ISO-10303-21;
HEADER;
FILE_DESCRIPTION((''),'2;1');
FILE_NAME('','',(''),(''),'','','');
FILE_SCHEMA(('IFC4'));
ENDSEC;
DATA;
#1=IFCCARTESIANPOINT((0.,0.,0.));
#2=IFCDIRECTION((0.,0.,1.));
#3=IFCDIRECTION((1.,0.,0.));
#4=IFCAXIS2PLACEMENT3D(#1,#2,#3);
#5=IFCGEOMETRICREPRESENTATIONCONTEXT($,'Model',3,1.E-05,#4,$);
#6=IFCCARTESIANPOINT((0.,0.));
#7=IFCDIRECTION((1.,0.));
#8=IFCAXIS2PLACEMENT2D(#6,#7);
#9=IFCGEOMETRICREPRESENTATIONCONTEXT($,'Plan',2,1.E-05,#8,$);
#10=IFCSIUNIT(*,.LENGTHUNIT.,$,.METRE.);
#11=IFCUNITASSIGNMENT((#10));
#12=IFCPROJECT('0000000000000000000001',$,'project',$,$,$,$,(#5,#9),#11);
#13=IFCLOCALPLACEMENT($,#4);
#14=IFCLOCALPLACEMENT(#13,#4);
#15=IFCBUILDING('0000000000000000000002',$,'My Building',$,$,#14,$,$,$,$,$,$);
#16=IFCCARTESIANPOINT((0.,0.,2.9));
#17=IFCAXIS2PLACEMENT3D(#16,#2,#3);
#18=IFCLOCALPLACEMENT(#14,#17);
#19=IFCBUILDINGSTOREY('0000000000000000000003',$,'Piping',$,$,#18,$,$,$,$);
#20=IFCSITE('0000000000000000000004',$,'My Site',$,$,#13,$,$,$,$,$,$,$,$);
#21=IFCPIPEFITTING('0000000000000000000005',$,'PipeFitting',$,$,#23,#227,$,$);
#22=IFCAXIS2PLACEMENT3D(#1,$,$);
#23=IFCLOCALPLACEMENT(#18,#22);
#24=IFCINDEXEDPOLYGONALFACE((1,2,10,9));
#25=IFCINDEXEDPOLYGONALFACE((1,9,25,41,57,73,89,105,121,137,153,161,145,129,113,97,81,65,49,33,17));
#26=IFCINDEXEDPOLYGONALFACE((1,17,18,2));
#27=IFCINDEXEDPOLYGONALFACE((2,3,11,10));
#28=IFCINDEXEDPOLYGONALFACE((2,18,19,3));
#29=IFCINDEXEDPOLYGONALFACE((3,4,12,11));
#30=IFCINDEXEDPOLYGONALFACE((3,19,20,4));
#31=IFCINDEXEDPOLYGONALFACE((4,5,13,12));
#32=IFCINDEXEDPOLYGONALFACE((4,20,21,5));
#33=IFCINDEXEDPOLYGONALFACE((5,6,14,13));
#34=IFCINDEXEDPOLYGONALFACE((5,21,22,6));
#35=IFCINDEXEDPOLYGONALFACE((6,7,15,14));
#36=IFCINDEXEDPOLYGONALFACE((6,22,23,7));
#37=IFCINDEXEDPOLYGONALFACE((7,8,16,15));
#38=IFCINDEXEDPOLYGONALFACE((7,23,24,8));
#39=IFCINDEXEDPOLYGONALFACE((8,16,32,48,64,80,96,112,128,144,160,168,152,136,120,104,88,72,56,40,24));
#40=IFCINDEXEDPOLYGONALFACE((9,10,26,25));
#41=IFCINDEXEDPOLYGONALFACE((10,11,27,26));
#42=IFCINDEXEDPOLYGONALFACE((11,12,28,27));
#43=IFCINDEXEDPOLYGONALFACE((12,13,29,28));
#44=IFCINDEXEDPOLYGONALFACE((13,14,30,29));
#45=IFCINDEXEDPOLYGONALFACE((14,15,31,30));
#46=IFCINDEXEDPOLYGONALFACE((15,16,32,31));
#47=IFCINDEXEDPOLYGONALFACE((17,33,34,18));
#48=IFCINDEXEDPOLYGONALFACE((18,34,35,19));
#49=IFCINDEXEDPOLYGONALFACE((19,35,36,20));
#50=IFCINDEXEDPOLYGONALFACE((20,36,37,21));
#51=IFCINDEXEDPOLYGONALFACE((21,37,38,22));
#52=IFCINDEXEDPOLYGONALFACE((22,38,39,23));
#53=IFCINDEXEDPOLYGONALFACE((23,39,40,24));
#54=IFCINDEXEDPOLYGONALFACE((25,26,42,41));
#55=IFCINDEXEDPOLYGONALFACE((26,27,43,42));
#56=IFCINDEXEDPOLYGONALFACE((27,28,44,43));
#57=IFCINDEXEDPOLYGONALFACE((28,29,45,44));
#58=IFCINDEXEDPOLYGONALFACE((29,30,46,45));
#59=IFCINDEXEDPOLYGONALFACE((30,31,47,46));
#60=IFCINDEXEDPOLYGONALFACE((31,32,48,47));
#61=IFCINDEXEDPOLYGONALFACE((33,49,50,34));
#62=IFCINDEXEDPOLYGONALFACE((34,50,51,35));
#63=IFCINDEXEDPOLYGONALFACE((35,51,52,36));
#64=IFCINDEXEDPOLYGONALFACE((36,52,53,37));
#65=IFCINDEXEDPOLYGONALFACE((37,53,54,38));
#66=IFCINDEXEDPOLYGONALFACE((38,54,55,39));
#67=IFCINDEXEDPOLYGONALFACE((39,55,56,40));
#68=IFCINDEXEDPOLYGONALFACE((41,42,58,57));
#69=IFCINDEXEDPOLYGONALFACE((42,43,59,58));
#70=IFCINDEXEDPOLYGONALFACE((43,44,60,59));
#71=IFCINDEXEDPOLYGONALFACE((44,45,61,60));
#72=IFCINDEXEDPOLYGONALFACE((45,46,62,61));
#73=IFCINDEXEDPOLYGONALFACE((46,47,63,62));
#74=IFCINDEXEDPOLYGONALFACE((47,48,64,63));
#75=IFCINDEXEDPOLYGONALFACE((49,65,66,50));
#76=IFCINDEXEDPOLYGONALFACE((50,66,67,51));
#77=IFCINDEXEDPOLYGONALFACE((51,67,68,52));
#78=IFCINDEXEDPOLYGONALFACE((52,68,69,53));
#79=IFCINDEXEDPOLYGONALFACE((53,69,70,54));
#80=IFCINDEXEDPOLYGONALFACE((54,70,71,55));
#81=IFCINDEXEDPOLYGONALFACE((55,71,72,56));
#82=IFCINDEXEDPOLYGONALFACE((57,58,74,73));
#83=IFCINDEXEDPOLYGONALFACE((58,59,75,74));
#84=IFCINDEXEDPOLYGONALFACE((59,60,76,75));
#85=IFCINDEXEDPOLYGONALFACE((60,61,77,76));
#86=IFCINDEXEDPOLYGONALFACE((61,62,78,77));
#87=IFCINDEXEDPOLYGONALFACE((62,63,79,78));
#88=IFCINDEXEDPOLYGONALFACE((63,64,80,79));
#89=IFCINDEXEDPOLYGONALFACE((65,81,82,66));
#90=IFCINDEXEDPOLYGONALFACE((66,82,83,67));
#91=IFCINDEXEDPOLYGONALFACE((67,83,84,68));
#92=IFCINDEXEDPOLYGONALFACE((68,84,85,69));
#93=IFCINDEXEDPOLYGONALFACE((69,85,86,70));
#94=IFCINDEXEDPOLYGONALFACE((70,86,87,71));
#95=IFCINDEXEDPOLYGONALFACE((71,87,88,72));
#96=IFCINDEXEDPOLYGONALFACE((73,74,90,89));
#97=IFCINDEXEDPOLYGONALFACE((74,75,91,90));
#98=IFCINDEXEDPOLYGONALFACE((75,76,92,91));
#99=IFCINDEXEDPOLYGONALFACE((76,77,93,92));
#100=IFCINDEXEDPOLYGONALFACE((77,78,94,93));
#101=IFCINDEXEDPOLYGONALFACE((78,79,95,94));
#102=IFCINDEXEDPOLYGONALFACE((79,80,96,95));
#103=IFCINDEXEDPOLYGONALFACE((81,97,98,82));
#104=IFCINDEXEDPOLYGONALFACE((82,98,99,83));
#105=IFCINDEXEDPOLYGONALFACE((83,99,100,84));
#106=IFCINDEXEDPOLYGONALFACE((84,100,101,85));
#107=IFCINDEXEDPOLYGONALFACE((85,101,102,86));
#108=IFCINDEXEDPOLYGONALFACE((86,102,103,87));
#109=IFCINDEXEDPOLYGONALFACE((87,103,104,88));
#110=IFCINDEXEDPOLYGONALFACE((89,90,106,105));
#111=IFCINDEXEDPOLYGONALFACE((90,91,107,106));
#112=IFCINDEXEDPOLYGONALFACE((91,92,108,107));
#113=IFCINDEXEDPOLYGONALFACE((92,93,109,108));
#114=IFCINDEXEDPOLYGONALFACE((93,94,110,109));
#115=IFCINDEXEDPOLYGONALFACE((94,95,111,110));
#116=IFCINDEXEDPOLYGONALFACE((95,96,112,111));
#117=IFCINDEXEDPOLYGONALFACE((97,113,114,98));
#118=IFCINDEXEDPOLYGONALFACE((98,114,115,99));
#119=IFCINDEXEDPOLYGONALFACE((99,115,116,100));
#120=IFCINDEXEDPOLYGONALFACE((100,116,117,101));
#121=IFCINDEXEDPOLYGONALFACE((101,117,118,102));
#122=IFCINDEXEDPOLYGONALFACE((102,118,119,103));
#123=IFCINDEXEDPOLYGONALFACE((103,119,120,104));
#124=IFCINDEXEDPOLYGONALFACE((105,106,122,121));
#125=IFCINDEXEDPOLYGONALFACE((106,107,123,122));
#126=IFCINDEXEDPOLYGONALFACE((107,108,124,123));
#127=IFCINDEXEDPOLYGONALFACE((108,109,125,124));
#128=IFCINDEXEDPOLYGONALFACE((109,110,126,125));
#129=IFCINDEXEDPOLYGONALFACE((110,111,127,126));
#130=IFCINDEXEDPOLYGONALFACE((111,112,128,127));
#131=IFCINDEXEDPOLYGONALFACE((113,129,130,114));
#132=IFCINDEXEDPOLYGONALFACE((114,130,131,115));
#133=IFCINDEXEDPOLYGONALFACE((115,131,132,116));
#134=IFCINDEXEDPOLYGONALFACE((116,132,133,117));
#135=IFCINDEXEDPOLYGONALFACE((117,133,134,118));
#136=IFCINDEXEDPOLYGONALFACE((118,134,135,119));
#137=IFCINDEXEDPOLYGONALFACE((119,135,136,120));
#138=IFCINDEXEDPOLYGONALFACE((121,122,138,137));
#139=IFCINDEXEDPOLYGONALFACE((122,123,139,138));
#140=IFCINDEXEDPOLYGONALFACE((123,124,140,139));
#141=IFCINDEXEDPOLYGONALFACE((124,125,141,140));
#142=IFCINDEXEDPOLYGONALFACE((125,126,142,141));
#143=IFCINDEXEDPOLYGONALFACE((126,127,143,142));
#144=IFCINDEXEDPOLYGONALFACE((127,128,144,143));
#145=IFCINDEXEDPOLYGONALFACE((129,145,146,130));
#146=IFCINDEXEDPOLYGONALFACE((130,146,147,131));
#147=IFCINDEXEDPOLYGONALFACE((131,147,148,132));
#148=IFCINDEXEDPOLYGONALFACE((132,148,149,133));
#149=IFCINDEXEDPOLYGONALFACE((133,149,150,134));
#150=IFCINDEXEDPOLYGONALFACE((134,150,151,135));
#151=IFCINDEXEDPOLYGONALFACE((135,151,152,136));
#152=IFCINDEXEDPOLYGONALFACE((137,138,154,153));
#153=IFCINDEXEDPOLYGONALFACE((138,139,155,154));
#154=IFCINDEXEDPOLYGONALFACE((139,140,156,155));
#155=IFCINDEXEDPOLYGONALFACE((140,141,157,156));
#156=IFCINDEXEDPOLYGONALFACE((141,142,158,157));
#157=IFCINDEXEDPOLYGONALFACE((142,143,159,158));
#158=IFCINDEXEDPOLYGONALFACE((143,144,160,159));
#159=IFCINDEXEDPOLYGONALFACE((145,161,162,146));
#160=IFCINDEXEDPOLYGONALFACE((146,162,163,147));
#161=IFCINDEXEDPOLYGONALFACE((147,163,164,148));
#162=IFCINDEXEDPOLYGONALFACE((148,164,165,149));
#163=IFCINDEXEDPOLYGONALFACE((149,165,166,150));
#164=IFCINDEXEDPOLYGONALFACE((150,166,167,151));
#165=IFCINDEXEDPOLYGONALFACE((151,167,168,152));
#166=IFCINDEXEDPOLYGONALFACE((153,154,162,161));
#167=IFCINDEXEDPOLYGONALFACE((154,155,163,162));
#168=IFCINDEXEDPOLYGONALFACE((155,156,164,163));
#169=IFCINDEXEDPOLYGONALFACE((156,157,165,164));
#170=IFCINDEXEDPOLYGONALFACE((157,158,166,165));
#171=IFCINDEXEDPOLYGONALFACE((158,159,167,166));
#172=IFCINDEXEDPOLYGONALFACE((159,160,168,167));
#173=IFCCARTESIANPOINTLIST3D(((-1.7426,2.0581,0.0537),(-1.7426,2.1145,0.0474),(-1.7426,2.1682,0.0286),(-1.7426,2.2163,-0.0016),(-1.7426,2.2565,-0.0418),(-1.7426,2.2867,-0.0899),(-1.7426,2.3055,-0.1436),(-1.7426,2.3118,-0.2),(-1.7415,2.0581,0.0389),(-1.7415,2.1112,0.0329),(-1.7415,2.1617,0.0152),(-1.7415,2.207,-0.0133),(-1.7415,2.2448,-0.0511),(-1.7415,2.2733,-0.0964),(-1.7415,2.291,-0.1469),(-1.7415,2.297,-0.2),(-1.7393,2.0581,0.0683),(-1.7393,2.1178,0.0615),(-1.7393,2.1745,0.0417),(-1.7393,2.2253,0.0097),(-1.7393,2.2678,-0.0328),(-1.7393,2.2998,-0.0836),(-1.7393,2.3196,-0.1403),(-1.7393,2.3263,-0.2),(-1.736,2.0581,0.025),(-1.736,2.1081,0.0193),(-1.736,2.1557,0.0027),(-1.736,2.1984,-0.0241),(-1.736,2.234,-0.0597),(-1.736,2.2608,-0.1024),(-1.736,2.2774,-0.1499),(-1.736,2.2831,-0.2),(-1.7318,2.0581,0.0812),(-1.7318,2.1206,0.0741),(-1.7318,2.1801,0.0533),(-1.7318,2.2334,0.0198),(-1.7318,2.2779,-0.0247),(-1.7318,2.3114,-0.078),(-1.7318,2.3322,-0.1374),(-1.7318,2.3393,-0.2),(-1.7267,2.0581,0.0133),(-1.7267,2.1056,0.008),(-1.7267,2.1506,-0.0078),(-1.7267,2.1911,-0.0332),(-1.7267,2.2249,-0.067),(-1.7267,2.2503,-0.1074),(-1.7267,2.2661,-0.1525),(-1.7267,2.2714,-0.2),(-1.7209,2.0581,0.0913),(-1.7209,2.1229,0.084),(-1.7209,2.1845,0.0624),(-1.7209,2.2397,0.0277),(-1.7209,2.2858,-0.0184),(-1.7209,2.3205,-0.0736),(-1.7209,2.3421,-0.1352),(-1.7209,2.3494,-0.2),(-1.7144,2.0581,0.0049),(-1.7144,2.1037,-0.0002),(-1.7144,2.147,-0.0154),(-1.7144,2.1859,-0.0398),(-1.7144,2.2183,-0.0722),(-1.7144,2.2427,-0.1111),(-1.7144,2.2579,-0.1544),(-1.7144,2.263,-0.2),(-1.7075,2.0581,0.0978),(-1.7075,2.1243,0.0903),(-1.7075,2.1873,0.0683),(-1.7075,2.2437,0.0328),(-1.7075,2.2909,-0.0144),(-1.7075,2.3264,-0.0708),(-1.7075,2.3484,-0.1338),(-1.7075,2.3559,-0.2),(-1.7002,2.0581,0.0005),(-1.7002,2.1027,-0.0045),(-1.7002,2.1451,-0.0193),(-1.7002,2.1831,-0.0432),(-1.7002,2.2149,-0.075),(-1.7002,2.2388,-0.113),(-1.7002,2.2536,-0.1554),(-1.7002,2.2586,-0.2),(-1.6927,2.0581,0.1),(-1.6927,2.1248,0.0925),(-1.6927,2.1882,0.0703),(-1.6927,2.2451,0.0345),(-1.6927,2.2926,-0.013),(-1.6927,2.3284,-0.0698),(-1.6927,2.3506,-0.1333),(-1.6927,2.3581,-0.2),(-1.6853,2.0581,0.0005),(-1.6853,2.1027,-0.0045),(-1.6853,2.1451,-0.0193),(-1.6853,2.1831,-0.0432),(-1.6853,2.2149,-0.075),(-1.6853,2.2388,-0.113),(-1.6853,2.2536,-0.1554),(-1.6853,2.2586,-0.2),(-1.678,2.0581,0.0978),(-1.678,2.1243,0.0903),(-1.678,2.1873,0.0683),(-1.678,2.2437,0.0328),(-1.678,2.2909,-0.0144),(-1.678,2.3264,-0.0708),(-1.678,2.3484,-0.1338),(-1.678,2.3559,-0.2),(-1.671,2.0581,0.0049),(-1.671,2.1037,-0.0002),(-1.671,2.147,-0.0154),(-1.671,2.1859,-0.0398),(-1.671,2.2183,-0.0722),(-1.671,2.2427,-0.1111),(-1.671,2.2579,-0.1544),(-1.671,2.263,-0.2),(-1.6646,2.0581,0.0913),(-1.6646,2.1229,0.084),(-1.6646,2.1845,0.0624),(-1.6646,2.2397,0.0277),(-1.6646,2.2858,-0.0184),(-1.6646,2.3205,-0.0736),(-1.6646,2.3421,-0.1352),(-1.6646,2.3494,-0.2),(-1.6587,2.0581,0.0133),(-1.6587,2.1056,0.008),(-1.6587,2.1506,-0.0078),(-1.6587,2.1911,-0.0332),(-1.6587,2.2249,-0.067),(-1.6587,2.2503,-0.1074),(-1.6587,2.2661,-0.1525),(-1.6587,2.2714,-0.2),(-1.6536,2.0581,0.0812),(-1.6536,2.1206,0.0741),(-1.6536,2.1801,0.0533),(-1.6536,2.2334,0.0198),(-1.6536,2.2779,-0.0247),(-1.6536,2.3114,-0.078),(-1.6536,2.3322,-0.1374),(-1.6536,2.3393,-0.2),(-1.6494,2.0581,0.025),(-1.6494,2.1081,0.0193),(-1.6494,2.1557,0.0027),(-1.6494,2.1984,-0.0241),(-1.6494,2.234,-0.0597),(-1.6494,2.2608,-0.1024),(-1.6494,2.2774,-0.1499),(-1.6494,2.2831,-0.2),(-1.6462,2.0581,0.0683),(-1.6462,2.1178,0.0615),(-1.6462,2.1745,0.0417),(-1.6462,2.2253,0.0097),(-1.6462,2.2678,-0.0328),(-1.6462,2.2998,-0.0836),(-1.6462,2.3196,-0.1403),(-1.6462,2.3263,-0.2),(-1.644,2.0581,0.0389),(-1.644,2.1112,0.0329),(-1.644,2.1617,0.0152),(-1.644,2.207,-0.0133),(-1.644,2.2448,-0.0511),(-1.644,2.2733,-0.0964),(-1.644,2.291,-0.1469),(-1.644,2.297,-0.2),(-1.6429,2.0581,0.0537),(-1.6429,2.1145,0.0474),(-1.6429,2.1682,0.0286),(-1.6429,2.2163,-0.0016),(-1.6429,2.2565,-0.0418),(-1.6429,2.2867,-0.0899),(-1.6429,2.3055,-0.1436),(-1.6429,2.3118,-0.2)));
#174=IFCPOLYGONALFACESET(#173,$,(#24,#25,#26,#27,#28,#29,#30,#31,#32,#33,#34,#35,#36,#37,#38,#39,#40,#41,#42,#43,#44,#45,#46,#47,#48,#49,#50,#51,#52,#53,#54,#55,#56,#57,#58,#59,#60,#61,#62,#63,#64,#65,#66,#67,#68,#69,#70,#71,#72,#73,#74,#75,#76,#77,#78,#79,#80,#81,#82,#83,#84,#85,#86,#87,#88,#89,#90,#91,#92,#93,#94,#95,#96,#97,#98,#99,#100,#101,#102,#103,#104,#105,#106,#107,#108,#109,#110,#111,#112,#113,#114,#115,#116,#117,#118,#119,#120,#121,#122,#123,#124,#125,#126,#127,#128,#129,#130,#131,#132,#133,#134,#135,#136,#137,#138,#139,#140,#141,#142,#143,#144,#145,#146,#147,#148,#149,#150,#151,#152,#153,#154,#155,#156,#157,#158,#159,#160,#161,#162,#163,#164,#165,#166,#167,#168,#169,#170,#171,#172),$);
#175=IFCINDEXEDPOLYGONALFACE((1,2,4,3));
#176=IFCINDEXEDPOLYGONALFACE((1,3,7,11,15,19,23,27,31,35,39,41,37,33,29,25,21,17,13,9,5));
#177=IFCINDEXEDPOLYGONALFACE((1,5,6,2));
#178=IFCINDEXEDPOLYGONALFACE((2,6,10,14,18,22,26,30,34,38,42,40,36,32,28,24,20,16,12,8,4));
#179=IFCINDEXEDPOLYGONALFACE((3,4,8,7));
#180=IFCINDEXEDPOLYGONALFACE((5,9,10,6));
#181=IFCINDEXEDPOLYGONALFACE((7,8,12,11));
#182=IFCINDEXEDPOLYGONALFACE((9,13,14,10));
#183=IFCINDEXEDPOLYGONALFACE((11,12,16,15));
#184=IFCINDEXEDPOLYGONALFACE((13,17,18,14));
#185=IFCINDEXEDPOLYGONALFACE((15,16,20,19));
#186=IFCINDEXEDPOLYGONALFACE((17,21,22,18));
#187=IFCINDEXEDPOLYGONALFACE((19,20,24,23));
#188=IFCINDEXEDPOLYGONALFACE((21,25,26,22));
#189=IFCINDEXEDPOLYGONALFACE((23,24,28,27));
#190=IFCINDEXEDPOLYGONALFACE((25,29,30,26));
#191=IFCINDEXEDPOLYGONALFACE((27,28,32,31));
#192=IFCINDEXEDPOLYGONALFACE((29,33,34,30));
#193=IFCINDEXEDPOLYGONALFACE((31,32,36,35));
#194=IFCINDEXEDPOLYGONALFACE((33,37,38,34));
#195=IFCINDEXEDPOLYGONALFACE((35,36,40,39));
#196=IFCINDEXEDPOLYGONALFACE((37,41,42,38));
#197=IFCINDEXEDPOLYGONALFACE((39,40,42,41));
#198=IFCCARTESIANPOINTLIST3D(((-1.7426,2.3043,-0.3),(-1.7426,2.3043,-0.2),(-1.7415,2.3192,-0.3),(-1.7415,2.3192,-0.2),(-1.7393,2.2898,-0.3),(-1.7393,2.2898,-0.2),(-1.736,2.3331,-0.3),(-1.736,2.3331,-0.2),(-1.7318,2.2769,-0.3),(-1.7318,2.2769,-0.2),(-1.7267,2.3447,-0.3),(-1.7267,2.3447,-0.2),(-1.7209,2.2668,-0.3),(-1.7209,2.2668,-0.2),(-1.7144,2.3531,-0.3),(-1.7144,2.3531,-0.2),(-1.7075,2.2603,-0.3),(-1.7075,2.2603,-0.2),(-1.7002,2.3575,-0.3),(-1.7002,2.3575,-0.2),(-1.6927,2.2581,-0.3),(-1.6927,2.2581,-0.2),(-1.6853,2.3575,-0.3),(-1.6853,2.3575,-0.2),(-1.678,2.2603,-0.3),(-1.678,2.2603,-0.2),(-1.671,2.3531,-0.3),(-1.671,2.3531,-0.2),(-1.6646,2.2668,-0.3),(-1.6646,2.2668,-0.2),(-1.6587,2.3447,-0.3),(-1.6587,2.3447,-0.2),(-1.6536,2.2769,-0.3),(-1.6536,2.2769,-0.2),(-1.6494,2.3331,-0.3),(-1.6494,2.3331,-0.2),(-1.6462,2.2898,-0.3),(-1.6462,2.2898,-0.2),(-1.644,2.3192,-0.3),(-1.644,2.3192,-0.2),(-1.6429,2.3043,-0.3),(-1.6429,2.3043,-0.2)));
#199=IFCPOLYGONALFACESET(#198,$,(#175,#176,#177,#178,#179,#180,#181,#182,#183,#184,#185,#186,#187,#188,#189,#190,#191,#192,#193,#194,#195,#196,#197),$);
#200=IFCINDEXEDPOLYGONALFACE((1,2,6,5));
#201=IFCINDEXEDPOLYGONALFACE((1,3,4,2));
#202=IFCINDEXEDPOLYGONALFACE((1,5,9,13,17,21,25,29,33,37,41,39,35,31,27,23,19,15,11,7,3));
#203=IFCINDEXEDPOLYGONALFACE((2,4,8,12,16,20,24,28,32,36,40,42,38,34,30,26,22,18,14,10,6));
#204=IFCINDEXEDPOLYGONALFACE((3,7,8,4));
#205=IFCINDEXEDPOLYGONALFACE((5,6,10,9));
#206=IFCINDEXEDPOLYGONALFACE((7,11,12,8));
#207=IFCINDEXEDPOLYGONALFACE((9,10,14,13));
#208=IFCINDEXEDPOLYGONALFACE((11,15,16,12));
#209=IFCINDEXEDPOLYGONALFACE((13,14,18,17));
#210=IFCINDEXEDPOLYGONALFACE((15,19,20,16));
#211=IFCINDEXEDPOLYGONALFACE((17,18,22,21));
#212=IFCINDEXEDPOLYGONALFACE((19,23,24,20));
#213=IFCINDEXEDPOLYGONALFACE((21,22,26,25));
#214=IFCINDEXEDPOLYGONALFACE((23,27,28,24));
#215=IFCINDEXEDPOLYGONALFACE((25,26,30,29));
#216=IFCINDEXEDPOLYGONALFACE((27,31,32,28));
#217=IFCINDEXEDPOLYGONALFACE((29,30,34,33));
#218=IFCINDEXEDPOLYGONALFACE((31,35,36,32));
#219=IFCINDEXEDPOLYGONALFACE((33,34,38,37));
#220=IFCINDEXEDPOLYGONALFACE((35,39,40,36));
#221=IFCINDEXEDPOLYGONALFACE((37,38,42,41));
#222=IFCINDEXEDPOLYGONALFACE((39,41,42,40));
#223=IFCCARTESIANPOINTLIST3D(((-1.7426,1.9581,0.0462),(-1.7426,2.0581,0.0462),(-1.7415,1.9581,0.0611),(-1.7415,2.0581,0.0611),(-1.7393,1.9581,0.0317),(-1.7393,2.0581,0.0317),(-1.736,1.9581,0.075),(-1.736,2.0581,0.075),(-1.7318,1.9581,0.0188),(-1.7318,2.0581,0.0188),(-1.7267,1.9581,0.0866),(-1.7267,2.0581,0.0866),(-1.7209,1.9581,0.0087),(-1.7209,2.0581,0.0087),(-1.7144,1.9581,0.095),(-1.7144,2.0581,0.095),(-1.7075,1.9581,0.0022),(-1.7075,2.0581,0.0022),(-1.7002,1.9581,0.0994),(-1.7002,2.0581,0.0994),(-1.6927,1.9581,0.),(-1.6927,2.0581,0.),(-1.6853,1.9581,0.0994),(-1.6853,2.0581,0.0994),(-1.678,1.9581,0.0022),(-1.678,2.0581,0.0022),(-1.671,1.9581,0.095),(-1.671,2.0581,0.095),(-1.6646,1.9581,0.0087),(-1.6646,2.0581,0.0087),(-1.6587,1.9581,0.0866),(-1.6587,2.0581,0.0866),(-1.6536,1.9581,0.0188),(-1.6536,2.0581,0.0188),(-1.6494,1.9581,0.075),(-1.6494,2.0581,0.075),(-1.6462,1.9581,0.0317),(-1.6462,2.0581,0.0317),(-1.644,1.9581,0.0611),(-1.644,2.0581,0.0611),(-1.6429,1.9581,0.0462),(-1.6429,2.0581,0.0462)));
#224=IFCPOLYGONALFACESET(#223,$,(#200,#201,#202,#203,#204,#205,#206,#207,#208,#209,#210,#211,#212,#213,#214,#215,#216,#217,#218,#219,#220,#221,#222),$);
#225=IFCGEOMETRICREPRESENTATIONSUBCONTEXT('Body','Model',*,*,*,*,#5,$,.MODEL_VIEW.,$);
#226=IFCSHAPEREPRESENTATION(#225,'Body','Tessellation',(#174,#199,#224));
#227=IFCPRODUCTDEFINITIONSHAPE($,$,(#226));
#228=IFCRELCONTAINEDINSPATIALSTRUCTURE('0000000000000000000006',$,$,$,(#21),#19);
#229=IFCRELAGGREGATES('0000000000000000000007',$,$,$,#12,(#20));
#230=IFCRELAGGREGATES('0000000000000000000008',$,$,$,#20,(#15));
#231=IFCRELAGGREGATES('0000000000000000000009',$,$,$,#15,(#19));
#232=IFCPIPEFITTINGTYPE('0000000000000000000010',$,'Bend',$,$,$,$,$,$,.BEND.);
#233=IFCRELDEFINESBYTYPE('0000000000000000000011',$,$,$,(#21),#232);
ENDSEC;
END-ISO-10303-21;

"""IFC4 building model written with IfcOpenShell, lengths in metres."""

from ifc_helpers import new_model, entity, si_unit, frame, origin_with_axes, origin_2d_with_axis, place, context, subcontext, project, spatial, circle, extrude, source, transform, mapped, type_object, type_shapes, element, save


model = new_model("IFC4")

# Units and contexts
model_context = context("Model", 3, precision=1e-05, world=origin_with_axes())
plan_context = context("Plan", 2, precision=1e-05, world=origin_2d_with_axis())
body_context = subcontext(model_context, "Body", "Model", "MODEL_VIEW")
ifc_project = project(units=[si_unit("LENGTHUNIT", "METRE")], contexts=[model_context, plan_context])

# Site, building, storey
site_placement = place(None, origin_with_axes())
site = spatial("IfcSite", under=ifc_project, at=site_placement, Name="My Site")
building_placement = place(site_placement, origin_with_axes())
building = spatial("IfcBuilding", under=site, at=building_placement, Name="My Building")
storey_placement = place(building_placement, frame((0.0, 0.0, 2.9), z_axis=(0.0, 0.0, 1.0), x_axis=(1.0, 0.0, 0.0)))
storey = spatial("IfcBuildingStorey", under=building, at=storey_placement, Name="Piping")

# Shared definitions
pipe_fitting_type_1 = type_object("IfcPipeFittingType", Name="Bend", PredefinedType="BEND")
shared_shape = source(origin_with_axes(), body_context, "Body", "SolidModel", [
    entity("IfcSweptDiskSolid", entity("IfcIndexedPolyCurve", entity("IfcCartesianPointList3D", [[0.0, 0.0, -0.1], [0.0732, 0.0, -0.2768], [0.25, 0.0, -0.35]]), [entity("IfcArcIndex", [1, 2, 3])]), 0.05),
    extrude(circle(Radius=0.05), origin_with_axes(), (0.0, 0.0, -1.0), 0.1),
    extrude(circle(Radius=0.05), frame((0.25, 0.0, -0.35), z_axis=(1.0, 0.0, 0.0), x_axis=(0.0, 0.0, 1.0)), (0.0, 0.0, 1.0), 0.1),
])
type_shapes(pipe_fitting_type_1, [shared_shape])

# Pipe fitting
for number, where, z_axis, x_axis, name in (
    (1, (-1.6927, 2.3081, -0.3), (0.0, 0.0, -1.0), (0.0, -1.0, 0.0), "PipeFitting"),
):
    element("IfcPipeFitting", number, at=place(storey_placement, frame(where, z_axis=z_axis, x_axis=x_axis)), inside=storey, type_object=pipe_fitting_type_1, Name=name, context=body_context, shape_type="MappedRepresentation", body=[
        mapped(shared_shape, transform((0.0, 0.0, 0.0), x_axis=(1.0, 0.0, 0.0), y_axis=(0.0, 1.0, 0.0), z_axis=(0.0, 0.0, 1.0), scale=1.0)),
    ])

save(model, "model.ifc")
